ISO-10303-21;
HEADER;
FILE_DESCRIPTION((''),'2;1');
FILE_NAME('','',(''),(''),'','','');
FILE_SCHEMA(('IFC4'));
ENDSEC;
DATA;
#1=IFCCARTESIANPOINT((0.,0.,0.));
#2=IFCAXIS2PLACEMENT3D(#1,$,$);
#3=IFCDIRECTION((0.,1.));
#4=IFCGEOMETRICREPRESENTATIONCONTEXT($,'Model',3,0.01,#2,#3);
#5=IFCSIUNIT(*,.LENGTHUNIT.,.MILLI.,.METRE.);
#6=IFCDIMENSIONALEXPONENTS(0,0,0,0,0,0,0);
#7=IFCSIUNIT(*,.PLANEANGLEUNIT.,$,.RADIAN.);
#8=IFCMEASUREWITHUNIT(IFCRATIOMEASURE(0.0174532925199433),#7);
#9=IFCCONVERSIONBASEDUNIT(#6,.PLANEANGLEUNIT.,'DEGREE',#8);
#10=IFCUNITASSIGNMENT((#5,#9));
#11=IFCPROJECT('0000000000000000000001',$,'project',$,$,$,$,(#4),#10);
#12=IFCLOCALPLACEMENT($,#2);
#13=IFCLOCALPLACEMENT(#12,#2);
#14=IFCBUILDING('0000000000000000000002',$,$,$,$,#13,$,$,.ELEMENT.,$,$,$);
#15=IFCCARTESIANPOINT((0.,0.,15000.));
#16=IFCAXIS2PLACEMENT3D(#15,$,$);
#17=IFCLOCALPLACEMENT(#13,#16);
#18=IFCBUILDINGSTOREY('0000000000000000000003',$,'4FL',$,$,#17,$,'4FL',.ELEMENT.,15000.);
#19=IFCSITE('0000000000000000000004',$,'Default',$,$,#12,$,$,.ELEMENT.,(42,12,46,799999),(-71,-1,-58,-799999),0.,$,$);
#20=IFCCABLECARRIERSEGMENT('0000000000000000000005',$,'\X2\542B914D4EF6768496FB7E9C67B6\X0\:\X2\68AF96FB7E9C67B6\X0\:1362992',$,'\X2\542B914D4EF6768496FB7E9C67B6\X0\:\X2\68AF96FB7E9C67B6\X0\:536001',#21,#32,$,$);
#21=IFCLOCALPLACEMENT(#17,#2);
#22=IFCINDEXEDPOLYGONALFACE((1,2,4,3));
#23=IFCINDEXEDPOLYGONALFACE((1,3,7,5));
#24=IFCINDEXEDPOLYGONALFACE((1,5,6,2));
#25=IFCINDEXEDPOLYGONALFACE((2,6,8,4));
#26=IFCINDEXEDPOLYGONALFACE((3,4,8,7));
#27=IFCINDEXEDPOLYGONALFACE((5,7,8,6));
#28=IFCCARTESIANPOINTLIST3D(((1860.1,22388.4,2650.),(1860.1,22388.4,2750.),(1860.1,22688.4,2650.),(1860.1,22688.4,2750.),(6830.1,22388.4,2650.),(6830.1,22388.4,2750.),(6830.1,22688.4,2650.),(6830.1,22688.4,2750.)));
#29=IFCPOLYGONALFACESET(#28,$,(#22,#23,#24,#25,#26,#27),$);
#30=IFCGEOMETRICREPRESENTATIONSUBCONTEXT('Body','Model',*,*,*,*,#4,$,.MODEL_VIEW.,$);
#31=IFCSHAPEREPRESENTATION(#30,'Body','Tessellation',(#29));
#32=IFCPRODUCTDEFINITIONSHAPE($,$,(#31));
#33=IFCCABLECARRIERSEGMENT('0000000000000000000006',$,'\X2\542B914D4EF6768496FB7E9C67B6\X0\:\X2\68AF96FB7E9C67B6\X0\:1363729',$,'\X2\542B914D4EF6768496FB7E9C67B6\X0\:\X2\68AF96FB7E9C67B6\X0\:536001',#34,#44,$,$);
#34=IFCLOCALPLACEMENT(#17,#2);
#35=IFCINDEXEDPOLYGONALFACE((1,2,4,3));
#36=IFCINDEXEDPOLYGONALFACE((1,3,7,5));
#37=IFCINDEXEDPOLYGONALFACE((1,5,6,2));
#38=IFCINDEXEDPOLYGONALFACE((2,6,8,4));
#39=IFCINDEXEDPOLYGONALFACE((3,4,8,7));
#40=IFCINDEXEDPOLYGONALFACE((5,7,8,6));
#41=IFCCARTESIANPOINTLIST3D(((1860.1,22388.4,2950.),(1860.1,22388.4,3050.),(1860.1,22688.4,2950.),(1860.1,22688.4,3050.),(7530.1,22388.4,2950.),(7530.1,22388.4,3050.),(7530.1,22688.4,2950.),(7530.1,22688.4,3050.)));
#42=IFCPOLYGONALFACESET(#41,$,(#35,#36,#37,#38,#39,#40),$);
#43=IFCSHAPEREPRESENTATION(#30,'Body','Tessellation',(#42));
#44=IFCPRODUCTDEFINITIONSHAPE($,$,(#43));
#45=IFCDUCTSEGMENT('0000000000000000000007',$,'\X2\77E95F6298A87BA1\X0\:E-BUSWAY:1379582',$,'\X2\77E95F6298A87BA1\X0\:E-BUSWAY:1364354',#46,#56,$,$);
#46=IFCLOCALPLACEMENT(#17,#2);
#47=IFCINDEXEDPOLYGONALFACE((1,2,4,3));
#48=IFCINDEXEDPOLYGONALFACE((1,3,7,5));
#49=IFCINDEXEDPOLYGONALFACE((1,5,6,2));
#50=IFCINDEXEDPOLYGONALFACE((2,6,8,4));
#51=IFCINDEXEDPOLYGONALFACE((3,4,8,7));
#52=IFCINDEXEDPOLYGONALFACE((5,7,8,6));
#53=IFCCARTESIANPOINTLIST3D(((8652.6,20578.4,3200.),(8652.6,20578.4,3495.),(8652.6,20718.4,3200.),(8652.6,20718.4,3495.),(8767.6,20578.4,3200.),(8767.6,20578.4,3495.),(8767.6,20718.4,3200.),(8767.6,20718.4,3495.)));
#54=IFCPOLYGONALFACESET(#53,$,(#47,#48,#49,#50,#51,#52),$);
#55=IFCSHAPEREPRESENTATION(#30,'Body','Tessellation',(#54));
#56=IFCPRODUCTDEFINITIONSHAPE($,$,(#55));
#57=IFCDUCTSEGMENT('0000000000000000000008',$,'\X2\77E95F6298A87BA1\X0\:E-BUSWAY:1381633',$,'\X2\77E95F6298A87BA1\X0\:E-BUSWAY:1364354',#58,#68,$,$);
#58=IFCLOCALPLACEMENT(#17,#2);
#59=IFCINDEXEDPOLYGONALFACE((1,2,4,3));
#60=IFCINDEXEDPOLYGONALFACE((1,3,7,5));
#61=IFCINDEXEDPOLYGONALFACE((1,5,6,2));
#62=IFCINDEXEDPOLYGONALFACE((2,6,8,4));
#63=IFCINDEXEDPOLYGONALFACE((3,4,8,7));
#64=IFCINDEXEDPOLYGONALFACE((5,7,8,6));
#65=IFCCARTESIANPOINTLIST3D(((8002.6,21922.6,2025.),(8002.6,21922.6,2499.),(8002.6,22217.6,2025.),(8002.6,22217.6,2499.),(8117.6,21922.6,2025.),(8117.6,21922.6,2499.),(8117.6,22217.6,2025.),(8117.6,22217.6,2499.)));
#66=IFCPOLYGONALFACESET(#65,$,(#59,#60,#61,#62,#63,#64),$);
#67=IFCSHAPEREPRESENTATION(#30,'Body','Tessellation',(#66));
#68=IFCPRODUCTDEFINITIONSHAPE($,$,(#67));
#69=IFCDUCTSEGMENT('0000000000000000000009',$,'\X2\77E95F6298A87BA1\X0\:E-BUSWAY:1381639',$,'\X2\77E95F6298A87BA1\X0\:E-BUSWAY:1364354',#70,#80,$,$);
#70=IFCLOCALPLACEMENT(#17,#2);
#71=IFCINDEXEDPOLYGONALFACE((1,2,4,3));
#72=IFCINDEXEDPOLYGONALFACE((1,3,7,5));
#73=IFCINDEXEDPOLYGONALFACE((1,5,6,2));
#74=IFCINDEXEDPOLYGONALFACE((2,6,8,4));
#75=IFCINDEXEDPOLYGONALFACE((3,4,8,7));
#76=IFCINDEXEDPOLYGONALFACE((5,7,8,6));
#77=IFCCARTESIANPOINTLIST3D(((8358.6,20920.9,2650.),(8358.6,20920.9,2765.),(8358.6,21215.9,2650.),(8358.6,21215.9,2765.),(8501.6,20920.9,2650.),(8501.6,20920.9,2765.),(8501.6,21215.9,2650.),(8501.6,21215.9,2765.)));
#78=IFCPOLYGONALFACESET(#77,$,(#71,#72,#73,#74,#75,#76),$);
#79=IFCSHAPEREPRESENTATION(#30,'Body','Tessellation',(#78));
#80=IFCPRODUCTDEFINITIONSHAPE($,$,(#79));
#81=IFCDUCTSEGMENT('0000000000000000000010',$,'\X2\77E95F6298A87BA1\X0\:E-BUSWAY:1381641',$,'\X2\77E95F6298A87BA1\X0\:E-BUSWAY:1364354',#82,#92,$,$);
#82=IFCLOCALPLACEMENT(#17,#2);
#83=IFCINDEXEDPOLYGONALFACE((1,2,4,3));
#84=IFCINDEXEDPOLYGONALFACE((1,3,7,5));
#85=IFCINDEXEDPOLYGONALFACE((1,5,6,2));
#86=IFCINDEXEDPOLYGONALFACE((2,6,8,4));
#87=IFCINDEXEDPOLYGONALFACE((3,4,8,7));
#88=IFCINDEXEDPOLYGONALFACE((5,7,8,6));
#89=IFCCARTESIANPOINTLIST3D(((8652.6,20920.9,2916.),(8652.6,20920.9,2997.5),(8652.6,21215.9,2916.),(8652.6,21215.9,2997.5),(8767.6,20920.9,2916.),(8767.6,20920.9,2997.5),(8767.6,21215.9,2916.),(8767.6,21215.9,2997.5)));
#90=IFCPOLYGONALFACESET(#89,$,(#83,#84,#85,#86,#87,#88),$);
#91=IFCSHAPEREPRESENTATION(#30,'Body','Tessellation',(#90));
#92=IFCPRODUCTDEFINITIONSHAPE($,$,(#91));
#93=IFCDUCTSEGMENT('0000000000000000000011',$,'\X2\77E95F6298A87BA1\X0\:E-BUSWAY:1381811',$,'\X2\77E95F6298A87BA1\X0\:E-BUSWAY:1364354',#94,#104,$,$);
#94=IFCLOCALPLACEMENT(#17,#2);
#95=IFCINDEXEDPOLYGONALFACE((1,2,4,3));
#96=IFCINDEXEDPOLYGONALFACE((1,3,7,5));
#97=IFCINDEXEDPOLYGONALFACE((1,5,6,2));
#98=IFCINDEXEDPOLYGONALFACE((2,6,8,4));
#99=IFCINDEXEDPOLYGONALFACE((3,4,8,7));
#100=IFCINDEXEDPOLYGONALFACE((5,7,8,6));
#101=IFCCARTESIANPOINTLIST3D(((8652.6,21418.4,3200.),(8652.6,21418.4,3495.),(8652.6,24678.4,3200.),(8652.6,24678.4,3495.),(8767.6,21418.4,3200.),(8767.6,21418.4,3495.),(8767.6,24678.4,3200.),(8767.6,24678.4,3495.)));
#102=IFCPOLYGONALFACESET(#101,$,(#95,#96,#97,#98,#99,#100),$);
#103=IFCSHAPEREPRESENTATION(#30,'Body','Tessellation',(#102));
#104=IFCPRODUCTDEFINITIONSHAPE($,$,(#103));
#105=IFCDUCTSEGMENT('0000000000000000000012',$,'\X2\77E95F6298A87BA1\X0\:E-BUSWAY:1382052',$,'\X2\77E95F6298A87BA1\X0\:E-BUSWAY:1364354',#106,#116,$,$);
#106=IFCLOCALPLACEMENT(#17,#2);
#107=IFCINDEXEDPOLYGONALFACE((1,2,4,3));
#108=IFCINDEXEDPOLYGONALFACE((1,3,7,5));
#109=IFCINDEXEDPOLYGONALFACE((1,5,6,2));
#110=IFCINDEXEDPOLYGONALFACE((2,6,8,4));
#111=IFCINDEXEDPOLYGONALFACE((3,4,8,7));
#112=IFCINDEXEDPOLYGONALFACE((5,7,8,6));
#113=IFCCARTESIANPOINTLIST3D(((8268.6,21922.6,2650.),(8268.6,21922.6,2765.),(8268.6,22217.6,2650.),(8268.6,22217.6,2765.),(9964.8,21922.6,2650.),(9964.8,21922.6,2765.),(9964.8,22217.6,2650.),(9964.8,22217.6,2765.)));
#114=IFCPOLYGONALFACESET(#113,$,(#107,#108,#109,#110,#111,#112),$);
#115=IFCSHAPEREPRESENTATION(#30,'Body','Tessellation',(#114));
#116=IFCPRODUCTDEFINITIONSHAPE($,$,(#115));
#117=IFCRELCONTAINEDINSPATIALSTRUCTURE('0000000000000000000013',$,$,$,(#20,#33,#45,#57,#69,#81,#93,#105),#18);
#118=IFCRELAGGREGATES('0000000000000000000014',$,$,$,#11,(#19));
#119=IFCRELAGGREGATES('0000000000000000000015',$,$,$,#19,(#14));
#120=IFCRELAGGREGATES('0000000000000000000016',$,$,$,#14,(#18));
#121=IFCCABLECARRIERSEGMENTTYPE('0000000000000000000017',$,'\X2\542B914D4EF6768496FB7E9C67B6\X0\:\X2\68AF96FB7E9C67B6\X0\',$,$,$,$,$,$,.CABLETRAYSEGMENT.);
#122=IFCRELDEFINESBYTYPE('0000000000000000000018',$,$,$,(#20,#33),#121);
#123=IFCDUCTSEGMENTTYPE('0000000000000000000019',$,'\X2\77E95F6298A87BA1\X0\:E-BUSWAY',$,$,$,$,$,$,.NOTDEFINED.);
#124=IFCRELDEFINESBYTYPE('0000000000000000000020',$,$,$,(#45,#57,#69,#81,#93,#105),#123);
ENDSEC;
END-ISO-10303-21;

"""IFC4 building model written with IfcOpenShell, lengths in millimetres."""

from ifc_helpers import new_model, entity, si_unit, converted_unit, direction, frame, frame_2d, origin, origin_2d_with_axis, place, context, subcontext, project, spatial, rectangle, extrude, type_object, element, save


model = new_model("IFC4")

# Units and contexts
model_context = context("Model", 3, precision=0.01, world=origin(), true_north=direction((0.0, 1.0)))
body_context = subcontext(model_context, "Body", "Model", "MODEL_VIEW")
ifc_project = project(units=[si_unit("LENGTHUNIT", "METRE", prefix="MILLI"), converted_unit("PLANEANGLEUNIT", "DEGREE", entity("IfcRatioMeasure", 0.0174532925199433), si_unit("PLANEANGLEUNIT", "RADIAN"), dimensions=[0, 0, 0, 0, 0, 0, 0])], contexts=[model_context])

# Site, building, storey
site_placement = place(None, origin())
site = spatial("IfcSite", under=ifc_project, at=site_placement, Name="Default", CompositionType="ELEMENT", RefLatitude=(42, 12, 46, 799999), RefLongitude=(-71, -1, -58, -799999), RefElevation=0.0)
building_placement = place(site_placement, origin())
building = spatial("IfcBuilding", under=site, at=building_placement, CompositionType="ELEMENT")
storey_placement = place(building_placement, frame((0.0, 0.0, 15000.0)))
storey = spatial("IfcBuildingStorey", under=building, at=storey_placement, Name="4FL", LongName="4FL", CompositionType="ELEMENT", Elevation=15000.0)

# Cable carrier segments
cable_carrier_segment_type_1 = type_object("IfcCableCarrierSegmentType", Name="含配件的電纜架:梯電纜架", PredefinedType="CABLETRAYSEGMENT")
cable_carrier_segment_1_placement = place(storey_placement, frame((1860.1, 22388.4, 2650.0)))
element("IfcCableCarrierSegment", 1, at=cable_carrier_segment_1_placement, inside=storey, type_object=cable_carrier_segment_type_1, Name="含配件的電纜架:梯電纜架:1362992", ObjectType="含配件的電纜架:梯電纜架:536001", context=body_context, shape_type="SweptSolid", body=[
    extrude(rectangle(XDim=4970.0, YDim=300.0, at=origin_2d_with_axis()), frame((2485.0, 150.0, 0.0)), (0.0, 0.0, 1.0), 100.0),
])
cable_carrier_segment_2_placement = place(storey_placement, frame((1860.1, 22388.4, 2950.0)))
element("IfcCableCarrierSegment", 2, at=cable_carrier_segment_2_placement, inside=storey, type_object=cable_carrier_segment_type_1, Name="含配件的電纜架:梯電纜架:1363729", ObjectType="含配件的電纜架:梯電纜架:536001", context=body_context, shape_type="SweptSolid", body=[
    extrude(rectangle(XDim=5670.0, YDim=300.0, at=origin_2d_with_axis()), frame((2835.0, 150.0, 0.0)), (0.0, 0.0, 1.0), 100.0),
])

# Duct segments
duct_segment_type = type_object("IfcDuctSegmentType", Name="矩形風管:E-BUSWAY", PredefinedType="NOTDEFINED")
duct_segment_1_placement = place(storey_placement, frame((8652.6, 20578.4, 3200.0)))
element("IfcDuctSegment", 3, at=duct_segment_1_placement, inside=storey, type_object=duct_segment_type, Name="矩形風管:E-BUSWAY:1379582", ObjectType="矩形風管:E-BUSWAY:1364354", context=body_context, shape_type="SweptSolid", body=[
    extrude(rectangle(XDim=140.0, YDim=115.0, at=frame_2d((0.0, 0.0), x_axis=(1.0, 0.0))), frame((57.5, 70.0, 0.0), z_axis=(0.0, 0.0, 1.0), x_axis=(0.0, -1.0, 0.0)), (0.0, 0.0, 1.0), 295.0),
])
duct_segment_2_placement = place(storey_placement, frame((8002.6, 21922.6, 2025.0)))
element("IfcDuctSegment", 4, at=duct_segment_2_placement, inside=storey, type_object=duct_segment_type, Name="矩形風管:E-BUSWAY:1381633", ObjectType="矩形風管:E-BUSWAY:1364354", context=body_context, shape_type="SweptSolid", body=[
    extrude(rectangle(XDim=115.0, YDim=295.0, at=origin_2d_with_axis()), frame((57.5, 147.5, 0.0), z_axis=(0.0, 0.0, 1.0), x_axis=(-1.0, 0.0, 0.0)), (0.0, 0.0, 1.0), 474.0),
])
duct_segment_3_placement = place(storey_placement, frame((8358.6, 20920.9, 2650.0)))
element("IfcDuctSegment", 5, at=duct_segment_3_placement, inside=storey, type_object=duct_segment_type, Name="矩形風管:E-BUSWAY:1381639", ObjectType="矩形風管:E-BUSWAY:1364354", context=body_context, shape_type="SweptSolid", body=[
    extrude(rectangle(XDim=143.0, YDim=295.0, at=frame_2d((0.0, 0.0), x_axis=(1.0, 0.0))), frame((71.5, 147.5, 0.0)), (0.0, 0.0, 1.0), 115.0),
])
duct_segment_4_placement = place(storey_placement, frame((8652.6, 20920.9, 2916.0)))
element("IfcDuctSegment", 6, at=duct_segment_4_placement, inside=storey, type_object=duct_segment_type, Name="矩形風管:E-BUSWAY:1381641", ObjectType="矩形風管:E-BUSWAY:1364354", context=body_context, shape_type="SweptSolid", body=[
    extrude(rectangle(XDim=115.0, YDim=295.0, at=frame_2d((0.0, 0.0), x_axis=(1.0, 0.0))), frame((57.5, 147.5, 0.0)), (0.0, 0.0, 1.0), 81.5),
])
duct_segment_5_placement = place(storey_placement, frame((8652.6, 21418.4, 3200.0)))
element("IfcDuctSegment", 7, at=duct_segment_5_placement, inside=storey, type_object=duct_segment_type, Name="矩形風管:E-BUSWAY:1381811", ObjectType="矩形風管:E-BUSWAY:1364354", context=body_context, shape_type="SweptSolid", body=[
    extrude(rectangle(XDim=3260.0, YDim=115.0, at=frame_2d((0.0, 0.0), x_axis=(1.0, 0.0))), frame((57.5, 1630.0, 0.0), z_axis=(0.0, 0.0, 1.0), x_axis=(0.0, -1.0, 0.0)), (0.0, 0.0, 1.0), 295.0),
])
duct_segment_6_placement = place(storey_placement, frame((8268.6, 21922.6, 2650.0)))
element("IfcDuctSegment", 8, at=duct_segment_6_placement, inside=storey, type_object=duct_segment_type, Name="矩形風管:E-BUSWAY:1382052", ObjectType="矩形風管:E-BUSWAY:1364354", context=body_context, shape_type="SweptSolid", body=[
    extrude(rectangle(XDim=1696.2, YDim=295.0, at=frame_2d((0.0, 0.0), x_axis=(1.0, 0.0))), frame((848.1, 147.5, 0.0)), (0.0, 0.0, 1.0), 115.0),
])

save(model, "model.ifc")
